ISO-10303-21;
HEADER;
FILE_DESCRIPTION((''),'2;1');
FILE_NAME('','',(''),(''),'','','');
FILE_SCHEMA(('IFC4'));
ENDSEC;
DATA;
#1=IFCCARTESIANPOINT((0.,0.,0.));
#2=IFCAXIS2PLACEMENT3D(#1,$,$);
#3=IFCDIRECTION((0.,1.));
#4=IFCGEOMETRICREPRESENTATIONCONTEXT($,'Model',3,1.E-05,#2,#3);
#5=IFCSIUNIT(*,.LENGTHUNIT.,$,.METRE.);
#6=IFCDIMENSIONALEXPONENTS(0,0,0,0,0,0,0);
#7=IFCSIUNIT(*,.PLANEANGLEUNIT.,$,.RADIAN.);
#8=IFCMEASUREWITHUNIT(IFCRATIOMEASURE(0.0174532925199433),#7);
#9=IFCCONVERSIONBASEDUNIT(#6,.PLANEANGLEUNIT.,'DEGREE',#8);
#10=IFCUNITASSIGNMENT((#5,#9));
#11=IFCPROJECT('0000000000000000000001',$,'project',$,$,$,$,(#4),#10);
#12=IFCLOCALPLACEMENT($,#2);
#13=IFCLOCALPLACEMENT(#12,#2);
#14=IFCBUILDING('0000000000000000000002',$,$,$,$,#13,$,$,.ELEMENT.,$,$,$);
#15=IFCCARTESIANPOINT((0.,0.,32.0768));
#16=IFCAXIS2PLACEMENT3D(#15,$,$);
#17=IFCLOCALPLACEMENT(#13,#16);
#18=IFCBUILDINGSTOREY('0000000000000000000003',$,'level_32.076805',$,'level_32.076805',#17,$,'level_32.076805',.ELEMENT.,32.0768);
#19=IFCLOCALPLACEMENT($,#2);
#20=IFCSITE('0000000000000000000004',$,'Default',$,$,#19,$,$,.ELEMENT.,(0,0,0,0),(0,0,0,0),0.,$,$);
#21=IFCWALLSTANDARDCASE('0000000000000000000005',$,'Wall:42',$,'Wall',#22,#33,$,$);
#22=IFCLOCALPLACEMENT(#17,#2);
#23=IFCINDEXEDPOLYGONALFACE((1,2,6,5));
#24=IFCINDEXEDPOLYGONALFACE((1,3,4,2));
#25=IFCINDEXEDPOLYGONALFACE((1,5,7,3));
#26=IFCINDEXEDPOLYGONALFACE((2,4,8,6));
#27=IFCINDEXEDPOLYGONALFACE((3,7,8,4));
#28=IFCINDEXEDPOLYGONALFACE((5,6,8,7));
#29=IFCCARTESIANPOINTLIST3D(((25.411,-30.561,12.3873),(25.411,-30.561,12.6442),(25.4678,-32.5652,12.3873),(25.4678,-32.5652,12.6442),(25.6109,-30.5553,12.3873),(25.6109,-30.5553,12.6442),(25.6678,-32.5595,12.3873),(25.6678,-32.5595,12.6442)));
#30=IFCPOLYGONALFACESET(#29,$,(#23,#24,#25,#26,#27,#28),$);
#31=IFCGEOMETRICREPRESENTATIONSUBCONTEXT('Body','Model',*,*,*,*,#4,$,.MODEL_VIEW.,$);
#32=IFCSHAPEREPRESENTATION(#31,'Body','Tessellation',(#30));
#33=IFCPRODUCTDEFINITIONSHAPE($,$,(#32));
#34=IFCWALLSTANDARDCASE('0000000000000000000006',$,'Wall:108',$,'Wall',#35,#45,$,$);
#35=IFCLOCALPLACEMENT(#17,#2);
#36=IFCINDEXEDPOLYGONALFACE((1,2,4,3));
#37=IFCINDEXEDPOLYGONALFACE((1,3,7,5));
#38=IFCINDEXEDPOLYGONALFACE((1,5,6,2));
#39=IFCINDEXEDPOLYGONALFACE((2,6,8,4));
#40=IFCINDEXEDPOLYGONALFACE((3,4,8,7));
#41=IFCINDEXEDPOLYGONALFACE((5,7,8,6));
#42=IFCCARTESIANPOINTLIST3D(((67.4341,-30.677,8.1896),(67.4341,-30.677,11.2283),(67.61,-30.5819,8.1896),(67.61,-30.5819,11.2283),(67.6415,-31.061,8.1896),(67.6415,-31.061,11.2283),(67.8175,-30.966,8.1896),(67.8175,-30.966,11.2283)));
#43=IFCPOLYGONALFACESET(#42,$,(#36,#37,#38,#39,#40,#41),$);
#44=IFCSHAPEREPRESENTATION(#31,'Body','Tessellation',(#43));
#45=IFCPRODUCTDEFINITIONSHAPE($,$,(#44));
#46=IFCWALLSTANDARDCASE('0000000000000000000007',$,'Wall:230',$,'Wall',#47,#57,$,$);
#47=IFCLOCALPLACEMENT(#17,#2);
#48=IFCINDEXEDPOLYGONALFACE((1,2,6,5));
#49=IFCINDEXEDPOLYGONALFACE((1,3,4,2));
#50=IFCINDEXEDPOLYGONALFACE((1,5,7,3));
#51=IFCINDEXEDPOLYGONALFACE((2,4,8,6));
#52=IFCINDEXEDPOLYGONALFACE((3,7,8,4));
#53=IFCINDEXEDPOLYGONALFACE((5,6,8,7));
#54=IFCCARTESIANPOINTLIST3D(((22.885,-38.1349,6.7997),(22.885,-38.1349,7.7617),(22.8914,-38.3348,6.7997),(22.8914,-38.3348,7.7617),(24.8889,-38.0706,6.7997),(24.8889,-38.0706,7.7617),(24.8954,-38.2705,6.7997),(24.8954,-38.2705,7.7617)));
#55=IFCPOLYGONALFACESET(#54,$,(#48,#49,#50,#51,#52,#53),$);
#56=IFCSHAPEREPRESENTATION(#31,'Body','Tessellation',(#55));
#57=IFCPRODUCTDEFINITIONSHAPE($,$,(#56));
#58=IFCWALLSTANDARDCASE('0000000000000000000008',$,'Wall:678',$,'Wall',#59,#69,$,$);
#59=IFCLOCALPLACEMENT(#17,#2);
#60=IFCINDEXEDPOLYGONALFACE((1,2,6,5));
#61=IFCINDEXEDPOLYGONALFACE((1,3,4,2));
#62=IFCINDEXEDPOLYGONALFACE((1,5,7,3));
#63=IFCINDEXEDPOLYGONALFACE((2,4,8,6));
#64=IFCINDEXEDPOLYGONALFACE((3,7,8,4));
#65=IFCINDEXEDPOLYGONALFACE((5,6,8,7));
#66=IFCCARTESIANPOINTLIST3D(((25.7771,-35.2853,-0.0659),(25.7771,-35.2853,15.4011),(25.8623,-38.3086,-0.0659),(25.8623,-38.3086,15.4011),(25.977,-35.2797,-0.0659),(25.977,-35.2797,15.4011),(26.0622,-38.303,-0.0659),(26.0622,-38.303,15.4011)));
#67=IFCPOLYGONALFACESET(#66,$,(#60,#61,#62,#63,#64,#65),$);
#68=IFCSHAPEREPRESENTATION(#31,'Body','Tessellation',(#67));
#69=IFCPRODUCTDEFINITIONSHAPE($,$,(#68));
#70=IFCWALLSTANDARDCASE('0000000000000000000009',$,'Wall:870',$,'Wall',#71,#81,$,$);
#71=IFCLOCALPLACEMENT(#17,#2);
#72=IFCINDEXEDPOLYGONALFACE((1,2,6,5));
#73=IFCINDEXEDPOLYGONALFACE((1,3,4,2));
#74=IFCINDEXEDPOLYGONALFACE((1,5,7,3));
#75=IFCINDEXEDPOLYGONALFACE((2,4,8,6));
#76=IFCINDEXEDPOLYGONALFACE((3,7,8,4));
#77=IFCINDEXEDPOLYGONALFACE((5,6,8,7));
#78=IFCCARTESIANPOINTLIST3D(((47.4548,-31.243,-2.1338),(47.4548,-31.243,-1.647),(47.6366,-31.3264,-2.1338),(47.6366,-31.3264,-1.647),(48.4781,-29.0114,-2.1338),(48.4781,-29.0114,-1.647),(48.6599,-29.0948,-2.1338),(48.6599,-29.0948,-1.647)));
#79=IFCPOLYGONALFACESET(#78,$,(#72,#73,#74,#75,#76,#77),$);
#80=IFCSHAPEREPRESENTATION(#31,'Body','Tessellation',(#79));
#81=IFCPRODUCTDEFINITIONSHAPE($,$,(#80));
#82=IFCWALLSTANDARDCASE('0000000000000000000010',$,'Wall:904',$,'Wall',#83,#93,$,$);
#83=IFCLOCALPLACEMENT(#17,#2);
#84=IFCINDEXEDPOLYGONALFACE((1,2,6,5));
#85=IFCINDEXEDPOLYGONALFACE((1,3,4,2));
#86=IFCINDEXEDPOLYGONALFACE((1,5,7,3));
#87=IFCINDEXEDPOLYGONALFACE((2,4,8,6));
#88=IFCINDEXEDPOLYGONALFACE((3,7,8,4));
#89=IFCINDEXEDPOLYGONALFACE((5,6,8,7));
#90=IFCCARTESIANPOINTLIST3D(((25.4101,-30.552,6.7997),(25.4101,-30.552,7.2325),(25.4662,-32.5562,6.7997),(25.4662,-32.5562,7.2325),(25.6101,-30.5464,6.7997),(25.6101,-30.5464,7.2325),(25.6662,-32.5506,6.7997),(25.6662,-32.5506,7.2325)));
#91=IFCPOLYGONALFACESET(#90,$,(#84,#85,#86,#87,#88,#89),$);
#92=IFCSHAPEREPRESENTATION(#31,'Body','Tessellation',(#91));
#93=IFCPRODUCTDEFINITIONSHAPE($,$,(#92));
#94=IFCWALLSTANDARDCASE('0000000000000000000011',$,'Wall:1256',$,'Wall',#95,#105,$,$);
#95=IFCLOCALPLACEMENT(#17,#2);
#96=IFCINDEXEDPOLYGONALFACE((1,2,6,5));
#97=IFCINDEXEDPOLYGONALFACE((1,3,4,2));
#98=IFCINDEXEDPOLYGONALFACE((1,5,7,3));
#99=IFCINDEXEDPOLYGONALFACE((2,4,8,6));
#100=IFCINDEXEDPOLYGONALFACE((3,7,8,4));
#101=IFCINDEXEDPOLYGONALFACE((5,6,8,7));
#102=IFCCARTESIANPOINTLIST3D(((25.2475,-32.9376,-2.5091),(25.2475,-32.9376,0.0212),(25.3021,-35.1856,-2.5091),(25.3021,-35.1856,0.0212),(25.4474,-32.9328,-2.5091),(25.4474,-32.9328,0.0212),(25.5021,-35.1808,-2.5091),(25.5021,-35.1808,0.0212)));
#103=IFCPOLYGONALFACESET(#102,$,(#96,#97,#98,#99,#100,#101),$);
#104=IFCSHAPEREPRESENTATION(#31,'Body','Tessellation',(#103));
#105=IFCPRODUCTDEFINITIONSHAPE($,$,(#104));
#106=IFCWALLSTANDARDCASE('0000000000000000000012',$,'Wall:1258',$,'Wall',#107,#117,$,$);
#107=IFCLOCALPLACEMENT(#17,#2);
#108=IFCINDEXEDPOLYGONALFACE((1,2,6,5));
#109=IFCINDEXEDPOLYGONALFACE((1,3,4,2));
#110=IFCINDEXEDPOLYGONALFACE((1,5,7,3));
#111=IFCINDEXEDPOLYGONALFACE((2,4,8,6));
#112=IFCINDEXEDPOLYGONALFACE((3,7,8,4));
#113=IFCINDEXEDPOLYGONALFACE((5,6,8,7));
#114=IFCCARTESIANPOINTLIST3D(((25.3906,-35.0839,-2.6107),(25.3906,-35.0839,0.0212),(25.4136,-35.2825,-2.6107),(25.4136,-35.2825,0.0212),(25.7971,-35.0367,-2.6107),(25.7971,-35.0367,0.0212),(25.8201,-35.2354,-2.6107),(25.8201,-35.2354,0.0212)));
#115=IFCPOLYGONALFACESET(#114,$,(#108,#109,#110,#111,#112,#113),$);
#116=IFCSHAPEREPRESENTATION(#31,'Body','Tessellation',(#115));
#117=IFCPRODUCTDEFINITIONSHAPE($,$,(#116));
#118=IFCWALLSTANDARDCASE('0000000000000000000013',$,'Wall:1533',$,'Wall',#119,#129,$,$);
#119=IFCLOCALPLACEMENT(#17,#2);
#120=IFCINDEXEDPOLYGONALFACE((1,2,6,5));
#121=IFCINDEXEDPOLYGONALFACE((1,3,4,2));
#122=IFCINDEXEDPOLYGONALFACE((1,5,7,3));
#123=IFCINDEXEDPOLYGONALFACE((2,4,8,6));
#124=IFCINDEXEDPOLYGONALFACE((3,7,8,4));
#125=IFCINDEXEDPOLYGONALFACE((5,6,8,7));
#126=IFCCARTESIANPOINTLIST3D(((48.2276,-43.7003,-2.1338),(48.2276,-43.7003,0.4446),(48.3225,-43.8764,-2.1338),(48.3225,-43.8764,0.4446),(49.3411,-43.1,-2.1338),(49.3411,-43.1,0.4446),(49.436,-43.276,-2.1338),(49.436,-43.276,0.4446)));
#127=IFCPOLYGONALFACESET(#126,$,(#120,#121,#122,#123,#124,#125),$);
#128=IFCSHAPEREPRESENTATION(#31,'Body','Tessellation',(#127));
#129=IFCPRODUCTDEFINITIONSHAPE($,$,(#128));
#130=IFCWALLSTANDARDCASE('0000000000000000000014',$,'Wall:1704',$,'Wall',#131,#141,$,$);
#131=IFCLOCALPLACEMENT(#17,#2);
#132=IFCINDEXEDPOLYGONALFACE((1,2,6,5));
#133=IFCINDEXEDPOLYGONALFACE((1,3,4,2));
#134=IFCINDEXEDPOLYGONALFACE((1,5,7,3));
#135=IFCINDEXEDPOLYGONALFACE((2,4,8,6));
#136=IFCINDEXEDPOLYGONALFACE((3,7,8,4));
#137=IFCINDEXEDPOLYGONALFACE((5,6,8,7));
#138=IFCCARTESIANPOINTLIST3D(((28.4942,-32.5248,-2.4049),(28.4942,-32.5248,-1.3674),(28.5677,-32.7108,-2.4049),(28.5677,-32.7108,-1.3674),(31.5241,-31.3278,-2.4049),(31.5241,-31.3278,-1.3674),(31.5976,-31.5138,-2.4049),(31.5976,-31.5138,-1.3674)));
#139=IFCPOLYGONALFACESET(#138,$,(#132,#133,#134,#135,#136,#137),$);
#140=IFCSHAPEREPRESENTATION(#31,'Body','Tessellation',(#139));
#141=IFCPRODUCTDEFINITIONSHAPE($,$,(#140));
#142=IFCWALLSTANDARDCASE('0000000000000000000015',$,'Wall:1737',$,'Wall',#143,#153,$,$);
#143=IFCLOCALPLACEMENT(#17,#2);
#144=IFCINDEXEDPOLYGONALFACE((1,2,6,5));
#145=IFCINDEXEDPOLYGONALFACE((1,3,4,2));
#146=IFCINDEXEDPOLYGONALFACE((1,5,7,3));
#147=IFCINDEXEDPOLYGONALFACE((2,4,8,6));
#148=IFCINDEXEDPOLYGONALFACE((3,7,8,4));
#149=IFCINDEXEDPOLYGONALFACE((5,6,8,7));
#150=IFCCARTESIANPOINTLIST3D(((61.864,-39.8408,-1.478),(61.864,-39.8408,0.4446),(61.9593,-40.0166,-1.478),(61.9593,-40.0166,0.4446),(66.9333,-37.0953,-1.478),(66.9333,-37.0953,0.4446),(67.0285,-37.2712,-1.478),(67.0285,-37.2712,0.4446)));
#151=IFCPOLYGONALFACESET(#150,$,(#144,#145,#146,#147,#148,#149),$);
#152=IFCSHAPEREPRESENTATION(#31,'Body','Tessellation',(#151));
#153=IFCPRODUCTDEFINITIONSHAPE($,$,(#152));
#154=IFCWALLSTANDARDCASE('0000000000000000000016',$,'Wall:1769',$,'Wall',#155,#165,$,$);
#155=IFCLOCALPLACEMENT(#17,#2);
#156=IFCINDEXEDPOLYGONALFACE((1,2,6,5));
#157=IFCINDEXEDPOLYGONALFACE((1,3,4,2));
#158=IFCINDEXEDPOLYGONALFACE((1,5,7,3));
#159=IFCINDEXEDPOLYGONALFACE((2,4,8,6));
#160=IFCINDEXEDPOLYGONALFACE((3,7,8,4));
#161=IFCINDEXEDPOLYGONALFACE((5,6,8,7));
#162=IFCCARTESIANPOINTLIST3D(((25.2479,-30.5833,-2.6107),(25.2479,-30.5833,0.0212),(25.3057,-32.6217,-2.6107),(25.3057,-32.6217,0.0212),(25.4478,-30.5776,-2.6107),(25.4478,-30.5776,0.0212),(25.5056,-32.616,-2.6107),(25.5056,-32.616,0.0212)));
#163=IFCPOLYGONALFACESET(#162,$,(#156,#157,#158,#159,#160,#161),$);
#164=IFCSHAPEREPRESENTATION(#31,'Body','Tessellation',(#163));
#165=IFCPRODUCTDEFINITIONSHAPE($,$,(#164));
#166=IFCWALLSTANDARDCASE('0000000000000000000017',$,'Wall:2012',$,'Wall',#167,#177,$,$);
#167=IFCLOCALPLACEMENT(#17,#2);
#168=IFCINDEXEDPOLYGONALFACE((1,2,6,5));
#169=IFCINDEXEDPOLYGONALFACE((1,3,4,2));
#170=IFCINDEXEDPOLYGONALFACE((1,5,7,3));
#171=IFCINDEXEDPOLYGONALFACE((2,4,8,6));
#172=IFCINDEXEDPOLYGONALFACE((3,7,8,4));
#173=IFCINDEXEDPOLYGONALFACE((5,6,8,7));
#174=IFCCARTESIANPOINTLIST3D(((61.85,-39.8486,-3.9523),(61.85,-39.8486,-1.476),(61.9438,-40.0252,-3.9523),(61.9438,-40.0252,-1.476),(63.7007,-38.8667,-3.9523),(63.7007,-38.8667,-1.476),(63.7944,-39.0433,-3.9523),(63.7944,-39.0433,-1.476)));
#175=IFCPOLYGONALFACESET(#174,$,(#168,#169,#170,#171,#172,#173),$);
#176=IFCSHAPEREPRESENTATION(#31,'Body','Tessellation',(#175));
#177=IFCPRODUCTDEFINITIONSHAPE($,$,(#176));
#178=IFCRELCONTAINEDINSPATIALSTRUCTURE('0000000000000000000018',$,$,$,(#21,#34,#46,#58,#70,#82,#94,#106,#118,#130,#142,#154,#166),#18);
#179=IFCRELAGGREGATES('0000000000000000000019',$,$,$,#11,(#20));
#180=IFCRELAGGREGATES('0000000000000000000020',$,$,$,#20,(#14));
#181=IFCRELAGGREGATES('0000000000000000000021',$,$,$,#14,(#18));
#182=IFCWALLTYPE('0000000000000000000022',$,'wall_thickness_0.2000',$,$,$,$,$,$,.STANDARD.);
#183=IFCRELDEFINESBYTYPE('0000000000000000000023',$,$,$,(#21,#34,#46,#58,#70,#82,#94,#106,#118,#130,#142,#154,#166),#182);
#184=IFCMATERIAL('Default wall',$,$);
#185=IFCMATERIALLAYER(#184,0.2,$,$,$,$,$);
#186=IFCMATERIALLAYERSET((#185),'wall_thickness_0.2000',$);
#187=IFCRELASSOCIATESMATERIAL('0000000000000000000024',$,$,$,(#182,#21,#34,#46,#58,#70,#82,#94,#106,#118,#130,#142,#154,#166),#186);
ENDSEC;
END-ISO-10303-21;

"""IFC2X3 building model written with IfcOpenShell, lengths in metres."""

from ifc_helpers import new_model, entity, si_unit, converted_unit, direction, frame, origin, place, context, subcontext, project, spatial, polyline, outline, extrude, material, layer, layer_set, layer_usage, type_object, element, save


model = new_model("IFC2X3")

# Units and contexts
model_context = context("Model", 3, precision=1e-05, world=origin(), true_north=direction((0.0, 1.0)))
body_context = subcontext(model_context, "Body", "Model", "MODEL_VIEW")
ifc_project = project(units=[si_unit("LENGTHUNIT", "METRE"), converted_unit("PLANEANGLEUNIT", "DEGREE", entity("IfcRatioMeasure", 0.0174532925199433), si_unit("PLANEANGLEUNIT", "RADIAN"), dimensions=[0, 0, 0, 0, 0, 0, 0])], contexts=[model_context])

# Site, building, storey
site_placement = place(None, origin())
site = spatial("IfcSite", under=ifc_project, at=site_placement, Name="Default", CompositionType="ELEMENT", RefLatitude=(0, 0, 0, 0), RefLongitude=(0, 0, 0, 0), RefElevation=0.0)
placement_1 = place(None, origin())
building_placement = place(placement_1, origin())
building = spatial("IfcBuilding", under=site, at=building_placement, CompositionType="ELEMENT")
storey_placement = place(building_placement, frame((0.0, 0.0, 32.0768)))
storey = spatial("IfcBuildingStorey", under=building, at=storey_placement, Name="level_32.076805", ObjectType="level_32.076805", LongName="level_32.076805", CompositionType="ELEMENT", Elevation=32.0768)

# Shared definitions
ifc_material_1 = material(Name="Default wall")
ifc_layer = layer(ifc_material_1, 0.2)
ifc_layer_set = layer_set([ifc_layer], Name="wall_thickness_0.2000")
ifc_layer_usage = layer_usage(ifc_layer_set, "AXIS2", "POSITIVE", -0.1)
wall_type = type_object("IfcWallType", Name="wall_thickness_0.2000", PredefinedType="STANDARD", material=ifc_layer_set)

# Walls
placement_2 = place(building_placement, frame((0.0, 0.0, 44.4641)))
wall_1_placement = place(placement_2, frame((25.5109, -30.5581, 0.0), z_axis=(0.0, 0.0, 1.0), x_axis=(0.028363, -0.999598, 0.0)))
element("IfcWallStandardCase", 1, at=wall_1_placement, inside=storey, type_object=wall_type, material=ifc_layer_usage, Name="Wall:42", ObjectType="Wall", context=body_context, shape_type="SweptSolid", body=[
    extrude(outline(polyline([(2.005, -0.1), (2.005, 0.1), (0.0, 0.1), (0.0, -0.1), (2.005, -0.1)])), origin(), (0.0, 0.0, 1.0), 0.2569),
])
placement_3 = place(building_placement, frame((0.0, 0.0, 40.2664)))
wall_2_placement = place(placement_3, frame((67.7295, -31.0135, 0.0), z_axis=(0.0, 0.0, 1.0), x_axis=(-0.475315, 0.879816, 0.0)))
element("IfcWallStandardCase", 2, at=wall_2_placement, inside=storey, type_object=wall_type, material=ifc_layer_usage, Name="Wall:108", ObjectType="Wall", context=body_context, shape_type="SweptSolid", body=[
    extrude(outline(polyline([(0.4365, -0.1), (0.4365, 0.1), (0.0, 0.1), (0.0, -0.1), (0.4365, -0.1)])), origin(), (0.0, 0.0, 1.0), 3.0386),
])
placement_4 = place(building_placement, frame((0.0, 0.0, 38.8765)))
wall_3_placement = place(placement_4, frame((22.8882, -38.2349, 0.0), z_axis=(0.0, 0.0, 1.0), x_axis=(0.999485, 0.032082, 0.0)))
element("IfcWallStandardCase", 3, at=wall_3_placement, inside=storey, type_object=wall_type, material=ifc_layer_usage, Name="Wall:230", ObjectType="Wall", context=body_context, shape_type="SweptSolid", body=[
    extrude(outline(polyline([(2.005, -0.1), (2.005, 0.1), (0.0, 0.1), (0.0, -0.1), (2.005, -0.1)])), origin(), (0.0, 0.0, 1.0), 0.962),
])
placement_5 = place(building_placement, frame((0.0, 0.0, 32.0109)))
wall_4_placement = place(placement_5, frame((25.877, -35.2825, 0.0), z_axis=(0.0, 0.0, 1.0), x_axis=(0.028164, -0.999603, 0.0)))
element("IfcWallStandardCase", 4, at=wall_4_placement, inside=storey, type_object=wall_type, material=ifc_layer_usage, Name="Wall:678", ObjectType="Wall", context=body_context, shape_type="SweptSolid", body=[
    extrude(outline(polyline([(3.0245, -0.1), (3.0245, 0.1), (0.0, 0.1), (0.0, -0.1), (3.0245, -0.1)])), origin(), (0.0, 0.0, 1.0), 15.467),
])
placement_6 = place(building_placement, frame((0.0, 0.0, 29.943)))
wall_5_placement = place(placement_6, frame((47.5457, -31.2847, 0.0), z_axis=(0.0, 0.0, 1.0), x_axis=(0.416809, 0.908994, 0.0)))
element("IfcWallStandardCase", 5, at=wall_5_placement, inside=storey, type_object=wall_type, material=ifc_layer_usage, Name="Wall:870", ObjectType="Wall", context=body_context, shape_type="SweptSolid", body=[
    extrude(outline(polyline([(2.455, -0.1), (2.455, 0.1), (0.0, 0.1), (0.0, -0.1), (2.455, -0.1)])), origin(), (0.0, 0.0, 1.0), 0.4867),
])
placement_7 = place(building_placement, frame((0.0, 0.0, 38.8765)))
wall_6_placement = place(placement_7, frame((25.5101, -30.5492, 0.0), z_axis=(0.0, 0.0, 1.0), x_axis=(0.027981, -0.999608, 0.0)))
element("IfcWallStandardCase", 6, at=wall_6_placement, inside=storey, type_object=wall_type, material=ifc_layer_usage, Name="Wall:904", ObjectType="Wall", context=body_context, shape_type="SweptSolid", body=[
    extrude(outline(polyline([(2.005, -0.1), (2.005, 0.1), (0.0, 0.1), (0.0, -0.1), (2.005, -0.1)])), origin(), (0.0, 0.0, 1.0), 0.4328),
])
placement_8 = place(building_placement, frame((0.0, 0.0, 29.5677)))
wall_7_placement = place(placement_8, frame((25.3475, -32.9352, 0.0), z_axis=(0.0, 0.0, 1.0), x_axis=(0.024288, -0.999705, 0.0)))
element("IfcWallStandardCase", 7, at=wall_7_placement, inside=storey, type_object=wall_type, material=ifc_layer_usage, Name="Wall:1256", ObjectType="Wall", context=body_context, shape_type="SweptSolid", body=[
    extrude(outline(polyline([(2.2486, -0.1), (2.2486, 0.1), (0.0, 0.1), (0.0, -0.1), (2.2486, -0.1)])), origin(), (0.0, 0.0, 1.0), 2.5303),
])
placement_9 = place(building_placement, frame((0.0, 0.0, 29.4661)))
wall_8_placement = place(placement_9, frame((25.4021, -35.1832, 0.0), z_axis=(0.0, 0.0, 1.0), x_axis=(0.993349, 0.11514, 0.0)))
element("IfcWallStandardCase", 8, at=wall_8_placement, inside=storey, type_object=wall_type, material=ifc_layer_usage, Name="Wall:1258", ObjectType="Wall", context=body_context, shape_type="SweptSolid", body=[
    extrude(outline(polyline([(0.4092, -0.1), (0.4092, 0.1), (0.0, 0.1), (0.0, -0.1), (0.4092, -0.1)])), origin(), (0.0, 0.0, 1.0), 2.632),
])
placement_10 = place(building_placement, frame((0.0, 0.0, 29.943)))
wall_9_placement = place(placement_10, frame((48.2751, -43.7883, 0.0), z_axis=(0.0, 0.0, 1.0), x_axis=(0.880211, 0.474583, 0.0)))
element("IfcWallStandardCase", 9, at=wall_9_placement, inside=storey, type_object=wall_type, material=ifc_layer_usage, Name="Wall:1533", ObjectType="Wall", context=body_context, shape_type="SweptSolid", body=[
    extrude(outline(polyline([(1.265, -0.1), (1.265, 0.1), (0.0, 0.1), (0.0, -0.1), (1.265, -0.1)])), origin(), (0.0, 0.0, 1.0), 2.5783),
])
placement_11 = place(building_placement, frame((0.0, 0.0, 29.6719)))
wall_10_placement = place(placement_11, frame((28.531, -32.6178, 0.0), z_axis=(0.0, 0.0, 1.0), x_axis=(0.93005, 0.367434, 0.0)))
element("IfcWallStandardCase", 10, at=wall_10_placement, inside=storey, type_object=wall_type, material=ifc_layer_usage, Name="Wall:1704", ObjectType="Wall", context=body_context, shape_type="SweptSolid", body=[
    extrude(outline(polyline([(3.2578, -0.1), (3.2578, 0.1), (0.0, 0.1), (0.0, -0.1), (3.2578, -0.1)])), origin(), (0.0, 0.0, 1.0), 1.0375),
])
placement_12 = place(building_placement, frame((0.0, 0.0, 30.5988)))
wall_11_placement = place(placement_12, frame((61.9116, -39.9287, 0.0), z_axis=(0.0, 0.0, 1.0), x_axis=(0.879322, 0.476228, 0.0)))
element("IfcWallStandardCase", 11, at=wall_11_placement, inside=storey, type_object=wall_type, material=ifc_layer_usage, Name="Wall:1737", ObjectType="Wall", context=body_context, shape_type="SweptSolid", body=[
    extrude(outline(polyline([(5.765, -0.1), (5.765, 0.1), (0.0, 0.1), (0.0, -0.1), (5.765, -0.1)])), origin(), (0.0, 0.0, 1.0), 1.9225),
])
placement_13 = place(building_placement, frame((0.0, 0.0, 29.4661)))
wall_12_placement = place(placement_13, frame((25.3478, -30.5805, 0.0), z_axis=(0.0, 0.0, 1.0), x_axis=(0.028337, -0.999598, 0.0)))
element("IfcWallStandardCase", 12, at=wall_12_placement, inside=storey, type_object=wall_type, material=ifc_layer_usage, Name="Wall:1769", ObjectType="Wall", context=body_context, shape_type="SweptSolid", body=[
    extrude(outline(polyline([(2.0392, -0.1), (2.0392, 0.1), (0.0, 0.1), (0.0, -0.1), (2.0392, -0.1)])), origin(), (0.0, 0.0, 1.0), 2.632),
])
placement_14 = place(building_placement, frame((0.0, 0.0, 28.1245)))
wall_13_placement = place(placement_14, frame((61.8969, -39.9369, 0.0), z_axis=(0.0, 0.0, 1.0), x_axis=(0.883365, 0.468686, 0.0)))
element("IfcWallStandardCase", 13, at=wall_13_placement, inside=storey, type_object=wall_type, material=ifc_layer_usage, Name="Wall:2012", ObjectType="Wall", context=body_context, shape_type="SweptSolid", body=[
    extrude(outline(polyline([(2.095, -0.1), (2.095, 0.1), (0.0, 0.1), (0.0, -0.1), (2.095, -0.1)])), origin(), (0.0, 0.0, 1.0), 2.4763),
])

save(model, "model.ifc")
